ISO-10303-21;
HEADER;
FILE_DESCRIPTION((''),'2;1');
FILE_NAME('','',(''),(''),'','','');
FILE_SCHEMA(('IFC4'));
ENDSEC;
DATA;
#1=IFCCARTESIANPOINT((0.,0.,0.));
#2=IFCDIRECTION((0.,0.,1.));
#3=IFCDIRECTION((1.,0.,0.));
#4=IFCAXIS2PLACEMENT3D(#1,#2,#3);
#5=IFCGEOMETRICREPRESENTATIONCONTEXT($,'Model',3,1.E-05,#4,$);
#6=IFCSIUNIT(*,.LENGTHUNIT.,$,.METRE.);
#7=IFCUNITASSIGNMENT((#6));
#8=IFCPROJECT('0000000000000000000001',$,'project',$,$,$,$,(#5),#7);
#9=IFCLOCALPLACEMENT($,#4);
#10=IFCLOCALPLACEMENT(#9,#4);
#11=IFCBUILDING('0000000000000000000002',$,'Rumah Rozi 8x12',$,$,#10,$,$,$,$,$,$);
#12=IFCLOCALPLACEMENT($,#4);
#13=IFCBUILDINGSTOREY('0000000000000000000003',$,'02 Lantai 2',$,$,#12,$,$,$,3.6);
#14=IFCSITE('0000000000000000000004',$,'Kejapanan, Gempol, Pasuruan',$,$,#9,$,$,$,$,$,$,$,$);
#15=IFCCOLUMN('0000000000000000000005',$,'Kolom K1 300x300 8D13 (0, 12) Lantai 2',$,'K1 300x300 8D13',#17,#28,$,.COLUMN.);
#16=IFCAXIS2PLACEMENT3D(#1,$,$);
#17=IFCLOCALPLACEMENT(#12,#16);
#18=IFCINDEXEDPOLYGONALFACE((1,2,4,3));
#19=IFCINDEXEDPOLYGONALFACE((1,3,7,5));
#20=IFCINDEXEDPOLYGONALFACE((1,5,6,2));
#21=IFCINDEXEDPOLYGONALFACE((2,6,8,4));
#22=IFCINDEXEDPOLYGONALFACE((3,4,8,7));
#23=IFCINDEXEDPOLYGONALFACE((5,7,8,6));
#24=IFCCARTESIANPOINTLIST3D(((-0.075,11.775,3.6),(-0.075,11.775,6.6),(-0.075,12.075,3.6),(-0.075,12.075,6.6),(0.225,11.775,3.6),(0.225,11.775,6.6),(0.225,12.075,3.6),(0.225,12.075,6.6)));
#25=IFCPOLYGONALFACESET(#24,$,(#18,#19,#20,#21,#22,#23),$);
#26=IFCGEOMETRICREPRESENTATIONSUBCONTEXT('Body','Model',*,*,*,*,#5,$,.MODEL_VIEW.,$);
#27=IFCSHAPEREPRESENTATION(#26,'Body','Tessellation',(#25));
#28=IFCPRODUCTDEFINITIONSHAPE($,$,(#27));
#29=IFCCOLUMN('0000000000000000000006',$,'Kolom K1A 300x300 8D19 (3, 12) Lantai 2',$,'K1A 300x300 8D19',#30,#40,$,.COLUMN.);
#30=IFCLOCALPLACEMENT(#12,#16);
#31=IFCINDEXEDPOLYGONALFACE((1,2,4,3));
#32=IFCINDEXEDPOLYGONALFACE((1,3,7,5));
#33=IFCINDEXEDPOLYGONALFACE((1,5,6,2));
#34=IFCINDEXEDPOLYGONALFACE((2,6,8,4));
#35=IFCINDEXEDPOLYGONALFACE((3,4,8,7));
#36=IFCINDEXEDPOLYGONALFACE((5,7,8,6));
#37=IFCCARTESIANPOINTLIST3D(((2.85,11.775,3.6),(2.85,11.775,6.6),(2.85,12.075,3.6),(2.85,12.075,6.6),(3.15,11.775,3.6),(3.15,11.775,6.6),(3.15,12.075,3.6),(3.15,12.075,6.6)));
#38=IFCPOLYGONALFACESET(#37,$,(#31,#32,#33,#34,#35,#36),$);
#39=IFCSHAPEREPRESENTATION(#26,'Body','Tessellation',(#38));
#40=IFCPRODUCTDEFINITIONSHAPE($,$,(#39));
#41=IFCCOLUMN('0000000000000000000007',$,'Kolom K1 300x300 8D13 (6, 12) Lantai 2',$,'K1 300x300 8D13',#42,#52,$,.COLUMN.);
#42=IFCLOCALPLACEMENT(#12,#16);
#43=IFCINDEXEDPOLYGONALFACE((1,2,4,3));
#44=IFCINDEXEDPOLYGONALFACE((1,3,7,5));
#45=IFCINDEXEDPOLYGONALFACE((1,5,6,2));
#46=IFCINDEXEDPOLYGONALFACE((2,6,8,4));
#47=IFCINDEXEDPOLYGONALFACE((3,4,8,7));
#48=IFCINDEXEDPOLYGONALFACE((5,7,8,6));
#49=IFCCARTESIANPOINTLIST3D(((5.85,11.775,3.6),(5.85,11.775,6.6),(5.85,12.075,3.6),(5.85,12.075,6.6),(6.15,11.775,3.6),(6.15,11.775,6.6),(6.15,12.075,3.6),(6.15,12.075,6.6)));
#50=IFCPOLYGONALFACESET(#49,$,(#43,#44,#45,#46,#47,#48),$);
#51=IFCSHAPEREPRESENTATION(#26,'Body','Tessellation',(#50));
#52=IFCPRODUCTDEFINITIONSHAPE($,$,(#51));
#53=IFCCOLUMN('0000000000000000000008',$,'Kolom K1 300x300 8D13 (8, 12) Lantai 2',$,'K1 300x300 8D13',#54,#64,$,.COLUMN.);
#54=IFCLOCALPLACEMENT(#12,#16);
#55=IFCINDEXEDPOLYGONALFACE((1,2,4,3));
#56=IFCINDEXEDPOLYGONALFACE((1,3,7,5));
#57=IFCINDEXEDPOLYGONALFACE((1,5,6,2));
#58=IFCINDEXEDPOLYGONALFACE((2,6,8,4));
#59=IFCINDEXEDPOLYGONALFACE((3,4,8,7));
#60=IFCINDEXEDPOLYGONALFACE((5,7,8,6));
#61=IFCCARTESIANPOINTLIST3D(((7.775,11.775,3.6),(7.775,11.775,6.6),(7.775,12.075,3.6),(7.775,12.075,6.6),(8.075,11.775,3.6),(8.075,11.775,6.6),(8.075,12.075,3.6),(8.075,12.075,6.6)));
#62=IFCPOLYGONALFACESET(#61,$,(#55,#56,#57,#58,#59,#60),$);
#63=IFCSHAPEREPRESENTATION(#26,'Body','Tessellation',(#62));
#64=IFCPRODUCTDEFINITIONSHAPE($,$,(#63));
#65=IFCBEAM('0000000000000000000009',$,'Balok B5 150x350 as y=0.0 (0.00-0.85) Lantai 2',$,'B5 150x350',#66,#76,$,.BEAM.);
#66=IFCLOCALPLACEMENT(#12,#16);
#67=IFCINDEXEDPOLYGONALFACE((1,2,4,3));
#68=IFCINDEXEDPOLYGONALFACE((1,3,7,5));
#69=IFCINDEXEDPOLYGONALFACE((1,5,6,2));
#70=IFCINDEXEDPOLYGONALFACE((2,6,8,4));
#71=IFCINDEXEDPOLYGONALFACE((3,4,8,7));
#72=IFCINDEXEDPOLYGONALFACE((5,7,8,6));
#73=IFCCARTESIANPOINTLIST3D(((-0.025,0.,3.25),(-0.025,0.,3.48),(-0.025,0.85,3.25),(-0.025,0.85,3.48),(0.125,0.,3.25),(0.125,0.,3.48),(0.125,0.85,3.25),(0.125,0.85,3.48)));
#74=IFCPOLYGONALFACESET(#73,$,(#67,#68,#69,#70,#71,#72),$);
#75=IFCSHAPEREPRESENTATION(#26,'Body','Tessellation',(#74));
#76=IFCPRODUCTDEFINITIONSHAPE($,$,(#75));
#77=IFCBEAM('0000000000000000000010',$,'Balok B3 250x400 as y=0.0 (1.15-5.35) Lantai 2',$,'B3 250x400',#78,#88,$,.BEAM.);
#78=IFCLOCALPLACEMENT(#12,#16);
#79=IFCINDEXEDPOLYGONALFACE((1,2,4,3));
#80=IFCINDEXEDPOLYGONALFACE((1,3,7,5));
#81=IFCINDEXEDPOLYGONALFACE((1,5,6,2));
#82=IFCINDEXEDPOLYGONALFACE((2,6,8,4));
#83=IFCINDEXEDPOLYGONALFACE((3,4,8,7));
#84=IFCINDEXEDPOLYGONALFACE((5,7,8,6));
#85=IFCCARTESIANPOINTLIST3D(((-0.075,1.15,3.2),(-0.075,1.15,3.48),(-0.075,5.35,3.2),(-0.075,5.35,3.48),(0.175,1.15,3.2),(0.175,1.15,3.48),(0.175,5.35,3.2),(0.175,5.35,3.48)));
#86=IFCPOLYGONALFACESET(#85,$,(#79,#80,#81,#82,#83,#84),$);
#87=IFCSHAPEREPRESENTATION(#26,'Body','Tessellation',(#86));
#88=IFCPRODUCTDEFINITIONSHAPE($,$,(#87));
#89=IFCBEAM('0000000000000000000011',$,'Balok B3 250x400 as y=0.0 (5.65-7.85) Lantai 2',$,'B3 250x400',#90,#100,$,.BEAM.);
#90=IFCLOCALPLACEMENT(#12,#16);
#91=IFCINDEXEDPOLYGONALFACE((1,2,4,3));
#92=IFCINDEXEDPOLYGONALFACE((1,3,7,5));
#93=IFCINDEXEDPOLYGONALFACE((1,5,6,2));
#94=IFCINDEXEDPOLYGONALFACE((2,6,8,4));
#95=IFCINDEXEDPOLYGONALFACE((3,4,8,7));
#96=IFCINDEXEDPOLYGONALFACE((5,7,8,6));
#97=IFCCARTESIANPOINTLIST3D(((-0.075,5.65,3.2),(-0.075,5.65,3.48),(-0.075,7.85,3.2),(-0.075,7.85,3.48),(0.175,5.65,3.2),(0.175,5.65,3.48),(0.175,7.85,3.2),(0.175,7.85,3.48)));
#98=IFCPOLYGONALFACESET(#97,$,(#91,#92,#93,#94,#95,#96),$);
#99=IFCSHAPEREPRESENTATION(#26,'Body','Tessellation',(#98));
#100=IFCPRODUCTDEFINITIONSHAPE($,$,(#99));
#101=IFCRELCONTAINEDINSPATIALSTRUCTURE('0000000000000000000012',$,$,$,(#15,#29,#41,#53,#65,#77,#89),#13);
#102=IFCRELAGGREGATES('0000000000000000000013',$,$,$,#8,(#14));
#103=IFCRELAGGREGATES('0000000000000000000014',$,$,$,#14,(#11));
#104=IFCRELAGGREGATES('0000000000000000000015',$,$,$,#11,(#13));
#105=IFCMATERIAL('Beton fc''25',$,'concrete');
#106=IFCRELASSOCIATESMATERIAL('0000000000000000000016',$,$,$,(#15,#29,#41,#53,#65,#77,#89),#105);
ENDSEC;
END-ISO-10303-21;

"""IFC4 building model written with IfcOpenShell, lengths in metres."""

from ifc_helpers import new_model, si_unit, frame, origin_with_axes, place, context, subcontext, project, spatial, line, indexed_curve, outline, extrude, material, element, save


model = new_model("IFC4")

# Units and contexts
model_context = context("Model", 3, precision=1e-05, world=origin_with_axes())
body_context = subcontext(model_context, "Body", "Model", "MODEL_VIEW")
ifc_project = project(units=[si_unit("LENGTHUNIT", "METRE")], contexts=[model_context])

# Site, building, storey
site_placement = place(None, origin_with_axes())
site = spatial("IfcSite", under=ifc_project, at=site_placement, Name="Kejapanan, Gempol, Pasuruan")
building_placement = place(site_placement, origin_with_axes())
building = spatial("IfcBuilding", under=site, at=building_placement, Name="Rumah Rozi 8x12")
storey_placement = place(None, origin_with_axes())
storey = spatial("IfcBuildingStorey", under=building, at=storey_placement, Name="02 Lantai 2", Elevation=3.6)

# Columns
ifc_material = material(Name="Beton fc'25", Category="concrete")
column_1_placement = place(storey_placement, origin_with_axes())
element("IfcColumn", 1, at=column_1_placement, inside=storey, material=ifc_material, Name="Kolom K1 300x300 8D13 (0, 12) Lantai 2", ObjectType="K1 300x300 8D13", PredefinedType="COLUMN", context=body_context, shape_type="SweptSolid", body=[
    extrude(outline(indexed_curve([(-0.075, 11.775), (0.225, 11.775), (0.225, 12.075), (-0.075, 12.075)], segments=[line(1, 2, 3, 4, 1)])), frame((0.0, 0.0, 3.6), z_axis=(0.0, 0.0, 1.0), x_axis=(1.0, 0.0, 0.0)), (0.0, 0.0, 1.0), 3.0),
])
column_2_placement = place(storey_placement, origin_with_axes())
element("IfcColumn", 2, at=column_2_placement, inside=storey, material=ifc_material, Name="Kolom K1A 300x300 8D19 (3, 12) Lantai 2", ObjectType="K1A 300x300 8D19", PredefinedType="COLUMN", context=body_context, shape_type="SweptSolid", body=[
    extrude(outline(indexed_curve([(2.85, 11.775), (3.15, 11.775), (3.15, 12.075), (2.85, 12.075)], segments=[line(1, 2, 3, 4, 1)])), frame((0.0, 0.0, 3.6), z_axis=(0.0, 0.0, 1.0), x_axis=(1.0, 0.0, 0.0)), (0.0, 0.0, 1.0), 3.0),
])
column_3_placement = place(storey_placement, origin_with_axes())
element("IfcColumn", 3, at=column_3_placement, inside=storey, material=ifc_material, Name="Kolom K1 300x300 8D13 (6, 12) Lantai 2", ObjectType="K1 300x300 8D13", PredefinedType="COLUMN", context=body_context, shape_type="SweptSolid", body=[
    extrude(outline(indexed_curve([(5.85, 11.775), (6.15, 11.775), (6.15, 12.075), (5.85, 12.075)], segments=[line(1, 2, 3, 4, 1)])), frame((0.0, 0.0, 3.6), z_axis=(0.0, 0.0, 1.0), x_axis=(1.0, 0.0, 0.0)), (0.0, 0.0, 1.0), 3.0),
])
column_4_placement = place(storey_placement, origin_with_axes())
element("IfcColumn", 4, at=column_4_placement, inside=storey, material=ifc_material, Name="Kolom K1 300x300 8D13 (8, 12) Lantai 2", ObjectType="K1 300x300 8D13", PredefinedType="COLUMN", context=body_context, shape_type="SweptSolid", body=[
    extrude(outline(indexed_curve([(7.775, 11.775), (8.075, 11.775), (8.075, 12.075), (7.775, 12.075)], segments=[line(1, 2, 3, 4, 1)])), frame((0.0, 0.0, 3.6), z_axis=(0.0, 0.0, 1.0), x_axis=(1.0, 0.0, 0.0)), (0.0, 0.0, 1.0), 3.0),
])

# Beams
beam_1_placement = place(storey_placement, origin_with_axes())
element("IfcBeam", 5, at=beam_1_placement, inside=storey, material=ifc_material, Name="Balok B5 150x350 as y=0.0 (0.00-0.85) Lantai 2", ObjectType="B5 150x350", PredefinedType="BEAM", context=body_context, shape_type="SweptSolid", body=[
    extrude(outline(indexed_curve([(-0.025, 0.0), (0.125, 0.0), (0.125, 0.85), (-0.025, 0.85)], segments=[line(1, 2, 3, 4, 1)])), frame((0.0, 0.0, 3.25), z_axis=(0.0, 0.0, 1.0), x_axis=(1.0, 0.0, 0.0)), (0.0, 0.0, 1.0), 0.23),
])
beam_2_placement = place(storey_placement, origin_with_axes())
element("IfcBeam", 6, at=beam_2_placement, inside=storey, material=ifc_material, Name="Balok B3 250x400 as y=0.0 (1.15-5.35) Lantai 2", ObjectType="B3 250x400", PredefinedType="BEAM", context=body_context, shape_type="SweptSolid", body=[
    extrude(outline(indexed_curve([(-0.075, 1.15), (0.175, 1.15), (0.175, 5.35), (-0.075, 5.35)], segments=[line(1, 2, 3, 4, 1)])), frame((0.0, 0.0, 3.2), z_axis=(0.0, 0.0, 1.0), x_axis=(1.0, 0.0, 0.0)), (0.0, 0.0, 1.0), 0.28),
])
beam_3_placement = place(storey_placement, origin_with_axes())
element("IfcBeam", 7, at=beam_3_placement, inside=storey, material=ifc_material, Name="Balok B3 250x400 as y=0.0 (5.65-7.85) Lantai 2", ObjectType="B3 250x400", PredefinedType="BEAM", context=body_context, shape_type="SweptSolid", body=[
    extrude(outline(indexed_curve([(-0.075, 5.65), (0.175, 5.65), (0.175, 7.85), (-0.075, 7.85)], segments=[line(1, 2, 3, 4, 1)])), frame((0.0, 0.0, 3.2), z_axis=(0.0, 0.0, 1.0), x_axis=(1.0, 0.0, 0.0)), (0.0, 0.0, 1.0), 0.28),
])

save(model, "model.ifc")
